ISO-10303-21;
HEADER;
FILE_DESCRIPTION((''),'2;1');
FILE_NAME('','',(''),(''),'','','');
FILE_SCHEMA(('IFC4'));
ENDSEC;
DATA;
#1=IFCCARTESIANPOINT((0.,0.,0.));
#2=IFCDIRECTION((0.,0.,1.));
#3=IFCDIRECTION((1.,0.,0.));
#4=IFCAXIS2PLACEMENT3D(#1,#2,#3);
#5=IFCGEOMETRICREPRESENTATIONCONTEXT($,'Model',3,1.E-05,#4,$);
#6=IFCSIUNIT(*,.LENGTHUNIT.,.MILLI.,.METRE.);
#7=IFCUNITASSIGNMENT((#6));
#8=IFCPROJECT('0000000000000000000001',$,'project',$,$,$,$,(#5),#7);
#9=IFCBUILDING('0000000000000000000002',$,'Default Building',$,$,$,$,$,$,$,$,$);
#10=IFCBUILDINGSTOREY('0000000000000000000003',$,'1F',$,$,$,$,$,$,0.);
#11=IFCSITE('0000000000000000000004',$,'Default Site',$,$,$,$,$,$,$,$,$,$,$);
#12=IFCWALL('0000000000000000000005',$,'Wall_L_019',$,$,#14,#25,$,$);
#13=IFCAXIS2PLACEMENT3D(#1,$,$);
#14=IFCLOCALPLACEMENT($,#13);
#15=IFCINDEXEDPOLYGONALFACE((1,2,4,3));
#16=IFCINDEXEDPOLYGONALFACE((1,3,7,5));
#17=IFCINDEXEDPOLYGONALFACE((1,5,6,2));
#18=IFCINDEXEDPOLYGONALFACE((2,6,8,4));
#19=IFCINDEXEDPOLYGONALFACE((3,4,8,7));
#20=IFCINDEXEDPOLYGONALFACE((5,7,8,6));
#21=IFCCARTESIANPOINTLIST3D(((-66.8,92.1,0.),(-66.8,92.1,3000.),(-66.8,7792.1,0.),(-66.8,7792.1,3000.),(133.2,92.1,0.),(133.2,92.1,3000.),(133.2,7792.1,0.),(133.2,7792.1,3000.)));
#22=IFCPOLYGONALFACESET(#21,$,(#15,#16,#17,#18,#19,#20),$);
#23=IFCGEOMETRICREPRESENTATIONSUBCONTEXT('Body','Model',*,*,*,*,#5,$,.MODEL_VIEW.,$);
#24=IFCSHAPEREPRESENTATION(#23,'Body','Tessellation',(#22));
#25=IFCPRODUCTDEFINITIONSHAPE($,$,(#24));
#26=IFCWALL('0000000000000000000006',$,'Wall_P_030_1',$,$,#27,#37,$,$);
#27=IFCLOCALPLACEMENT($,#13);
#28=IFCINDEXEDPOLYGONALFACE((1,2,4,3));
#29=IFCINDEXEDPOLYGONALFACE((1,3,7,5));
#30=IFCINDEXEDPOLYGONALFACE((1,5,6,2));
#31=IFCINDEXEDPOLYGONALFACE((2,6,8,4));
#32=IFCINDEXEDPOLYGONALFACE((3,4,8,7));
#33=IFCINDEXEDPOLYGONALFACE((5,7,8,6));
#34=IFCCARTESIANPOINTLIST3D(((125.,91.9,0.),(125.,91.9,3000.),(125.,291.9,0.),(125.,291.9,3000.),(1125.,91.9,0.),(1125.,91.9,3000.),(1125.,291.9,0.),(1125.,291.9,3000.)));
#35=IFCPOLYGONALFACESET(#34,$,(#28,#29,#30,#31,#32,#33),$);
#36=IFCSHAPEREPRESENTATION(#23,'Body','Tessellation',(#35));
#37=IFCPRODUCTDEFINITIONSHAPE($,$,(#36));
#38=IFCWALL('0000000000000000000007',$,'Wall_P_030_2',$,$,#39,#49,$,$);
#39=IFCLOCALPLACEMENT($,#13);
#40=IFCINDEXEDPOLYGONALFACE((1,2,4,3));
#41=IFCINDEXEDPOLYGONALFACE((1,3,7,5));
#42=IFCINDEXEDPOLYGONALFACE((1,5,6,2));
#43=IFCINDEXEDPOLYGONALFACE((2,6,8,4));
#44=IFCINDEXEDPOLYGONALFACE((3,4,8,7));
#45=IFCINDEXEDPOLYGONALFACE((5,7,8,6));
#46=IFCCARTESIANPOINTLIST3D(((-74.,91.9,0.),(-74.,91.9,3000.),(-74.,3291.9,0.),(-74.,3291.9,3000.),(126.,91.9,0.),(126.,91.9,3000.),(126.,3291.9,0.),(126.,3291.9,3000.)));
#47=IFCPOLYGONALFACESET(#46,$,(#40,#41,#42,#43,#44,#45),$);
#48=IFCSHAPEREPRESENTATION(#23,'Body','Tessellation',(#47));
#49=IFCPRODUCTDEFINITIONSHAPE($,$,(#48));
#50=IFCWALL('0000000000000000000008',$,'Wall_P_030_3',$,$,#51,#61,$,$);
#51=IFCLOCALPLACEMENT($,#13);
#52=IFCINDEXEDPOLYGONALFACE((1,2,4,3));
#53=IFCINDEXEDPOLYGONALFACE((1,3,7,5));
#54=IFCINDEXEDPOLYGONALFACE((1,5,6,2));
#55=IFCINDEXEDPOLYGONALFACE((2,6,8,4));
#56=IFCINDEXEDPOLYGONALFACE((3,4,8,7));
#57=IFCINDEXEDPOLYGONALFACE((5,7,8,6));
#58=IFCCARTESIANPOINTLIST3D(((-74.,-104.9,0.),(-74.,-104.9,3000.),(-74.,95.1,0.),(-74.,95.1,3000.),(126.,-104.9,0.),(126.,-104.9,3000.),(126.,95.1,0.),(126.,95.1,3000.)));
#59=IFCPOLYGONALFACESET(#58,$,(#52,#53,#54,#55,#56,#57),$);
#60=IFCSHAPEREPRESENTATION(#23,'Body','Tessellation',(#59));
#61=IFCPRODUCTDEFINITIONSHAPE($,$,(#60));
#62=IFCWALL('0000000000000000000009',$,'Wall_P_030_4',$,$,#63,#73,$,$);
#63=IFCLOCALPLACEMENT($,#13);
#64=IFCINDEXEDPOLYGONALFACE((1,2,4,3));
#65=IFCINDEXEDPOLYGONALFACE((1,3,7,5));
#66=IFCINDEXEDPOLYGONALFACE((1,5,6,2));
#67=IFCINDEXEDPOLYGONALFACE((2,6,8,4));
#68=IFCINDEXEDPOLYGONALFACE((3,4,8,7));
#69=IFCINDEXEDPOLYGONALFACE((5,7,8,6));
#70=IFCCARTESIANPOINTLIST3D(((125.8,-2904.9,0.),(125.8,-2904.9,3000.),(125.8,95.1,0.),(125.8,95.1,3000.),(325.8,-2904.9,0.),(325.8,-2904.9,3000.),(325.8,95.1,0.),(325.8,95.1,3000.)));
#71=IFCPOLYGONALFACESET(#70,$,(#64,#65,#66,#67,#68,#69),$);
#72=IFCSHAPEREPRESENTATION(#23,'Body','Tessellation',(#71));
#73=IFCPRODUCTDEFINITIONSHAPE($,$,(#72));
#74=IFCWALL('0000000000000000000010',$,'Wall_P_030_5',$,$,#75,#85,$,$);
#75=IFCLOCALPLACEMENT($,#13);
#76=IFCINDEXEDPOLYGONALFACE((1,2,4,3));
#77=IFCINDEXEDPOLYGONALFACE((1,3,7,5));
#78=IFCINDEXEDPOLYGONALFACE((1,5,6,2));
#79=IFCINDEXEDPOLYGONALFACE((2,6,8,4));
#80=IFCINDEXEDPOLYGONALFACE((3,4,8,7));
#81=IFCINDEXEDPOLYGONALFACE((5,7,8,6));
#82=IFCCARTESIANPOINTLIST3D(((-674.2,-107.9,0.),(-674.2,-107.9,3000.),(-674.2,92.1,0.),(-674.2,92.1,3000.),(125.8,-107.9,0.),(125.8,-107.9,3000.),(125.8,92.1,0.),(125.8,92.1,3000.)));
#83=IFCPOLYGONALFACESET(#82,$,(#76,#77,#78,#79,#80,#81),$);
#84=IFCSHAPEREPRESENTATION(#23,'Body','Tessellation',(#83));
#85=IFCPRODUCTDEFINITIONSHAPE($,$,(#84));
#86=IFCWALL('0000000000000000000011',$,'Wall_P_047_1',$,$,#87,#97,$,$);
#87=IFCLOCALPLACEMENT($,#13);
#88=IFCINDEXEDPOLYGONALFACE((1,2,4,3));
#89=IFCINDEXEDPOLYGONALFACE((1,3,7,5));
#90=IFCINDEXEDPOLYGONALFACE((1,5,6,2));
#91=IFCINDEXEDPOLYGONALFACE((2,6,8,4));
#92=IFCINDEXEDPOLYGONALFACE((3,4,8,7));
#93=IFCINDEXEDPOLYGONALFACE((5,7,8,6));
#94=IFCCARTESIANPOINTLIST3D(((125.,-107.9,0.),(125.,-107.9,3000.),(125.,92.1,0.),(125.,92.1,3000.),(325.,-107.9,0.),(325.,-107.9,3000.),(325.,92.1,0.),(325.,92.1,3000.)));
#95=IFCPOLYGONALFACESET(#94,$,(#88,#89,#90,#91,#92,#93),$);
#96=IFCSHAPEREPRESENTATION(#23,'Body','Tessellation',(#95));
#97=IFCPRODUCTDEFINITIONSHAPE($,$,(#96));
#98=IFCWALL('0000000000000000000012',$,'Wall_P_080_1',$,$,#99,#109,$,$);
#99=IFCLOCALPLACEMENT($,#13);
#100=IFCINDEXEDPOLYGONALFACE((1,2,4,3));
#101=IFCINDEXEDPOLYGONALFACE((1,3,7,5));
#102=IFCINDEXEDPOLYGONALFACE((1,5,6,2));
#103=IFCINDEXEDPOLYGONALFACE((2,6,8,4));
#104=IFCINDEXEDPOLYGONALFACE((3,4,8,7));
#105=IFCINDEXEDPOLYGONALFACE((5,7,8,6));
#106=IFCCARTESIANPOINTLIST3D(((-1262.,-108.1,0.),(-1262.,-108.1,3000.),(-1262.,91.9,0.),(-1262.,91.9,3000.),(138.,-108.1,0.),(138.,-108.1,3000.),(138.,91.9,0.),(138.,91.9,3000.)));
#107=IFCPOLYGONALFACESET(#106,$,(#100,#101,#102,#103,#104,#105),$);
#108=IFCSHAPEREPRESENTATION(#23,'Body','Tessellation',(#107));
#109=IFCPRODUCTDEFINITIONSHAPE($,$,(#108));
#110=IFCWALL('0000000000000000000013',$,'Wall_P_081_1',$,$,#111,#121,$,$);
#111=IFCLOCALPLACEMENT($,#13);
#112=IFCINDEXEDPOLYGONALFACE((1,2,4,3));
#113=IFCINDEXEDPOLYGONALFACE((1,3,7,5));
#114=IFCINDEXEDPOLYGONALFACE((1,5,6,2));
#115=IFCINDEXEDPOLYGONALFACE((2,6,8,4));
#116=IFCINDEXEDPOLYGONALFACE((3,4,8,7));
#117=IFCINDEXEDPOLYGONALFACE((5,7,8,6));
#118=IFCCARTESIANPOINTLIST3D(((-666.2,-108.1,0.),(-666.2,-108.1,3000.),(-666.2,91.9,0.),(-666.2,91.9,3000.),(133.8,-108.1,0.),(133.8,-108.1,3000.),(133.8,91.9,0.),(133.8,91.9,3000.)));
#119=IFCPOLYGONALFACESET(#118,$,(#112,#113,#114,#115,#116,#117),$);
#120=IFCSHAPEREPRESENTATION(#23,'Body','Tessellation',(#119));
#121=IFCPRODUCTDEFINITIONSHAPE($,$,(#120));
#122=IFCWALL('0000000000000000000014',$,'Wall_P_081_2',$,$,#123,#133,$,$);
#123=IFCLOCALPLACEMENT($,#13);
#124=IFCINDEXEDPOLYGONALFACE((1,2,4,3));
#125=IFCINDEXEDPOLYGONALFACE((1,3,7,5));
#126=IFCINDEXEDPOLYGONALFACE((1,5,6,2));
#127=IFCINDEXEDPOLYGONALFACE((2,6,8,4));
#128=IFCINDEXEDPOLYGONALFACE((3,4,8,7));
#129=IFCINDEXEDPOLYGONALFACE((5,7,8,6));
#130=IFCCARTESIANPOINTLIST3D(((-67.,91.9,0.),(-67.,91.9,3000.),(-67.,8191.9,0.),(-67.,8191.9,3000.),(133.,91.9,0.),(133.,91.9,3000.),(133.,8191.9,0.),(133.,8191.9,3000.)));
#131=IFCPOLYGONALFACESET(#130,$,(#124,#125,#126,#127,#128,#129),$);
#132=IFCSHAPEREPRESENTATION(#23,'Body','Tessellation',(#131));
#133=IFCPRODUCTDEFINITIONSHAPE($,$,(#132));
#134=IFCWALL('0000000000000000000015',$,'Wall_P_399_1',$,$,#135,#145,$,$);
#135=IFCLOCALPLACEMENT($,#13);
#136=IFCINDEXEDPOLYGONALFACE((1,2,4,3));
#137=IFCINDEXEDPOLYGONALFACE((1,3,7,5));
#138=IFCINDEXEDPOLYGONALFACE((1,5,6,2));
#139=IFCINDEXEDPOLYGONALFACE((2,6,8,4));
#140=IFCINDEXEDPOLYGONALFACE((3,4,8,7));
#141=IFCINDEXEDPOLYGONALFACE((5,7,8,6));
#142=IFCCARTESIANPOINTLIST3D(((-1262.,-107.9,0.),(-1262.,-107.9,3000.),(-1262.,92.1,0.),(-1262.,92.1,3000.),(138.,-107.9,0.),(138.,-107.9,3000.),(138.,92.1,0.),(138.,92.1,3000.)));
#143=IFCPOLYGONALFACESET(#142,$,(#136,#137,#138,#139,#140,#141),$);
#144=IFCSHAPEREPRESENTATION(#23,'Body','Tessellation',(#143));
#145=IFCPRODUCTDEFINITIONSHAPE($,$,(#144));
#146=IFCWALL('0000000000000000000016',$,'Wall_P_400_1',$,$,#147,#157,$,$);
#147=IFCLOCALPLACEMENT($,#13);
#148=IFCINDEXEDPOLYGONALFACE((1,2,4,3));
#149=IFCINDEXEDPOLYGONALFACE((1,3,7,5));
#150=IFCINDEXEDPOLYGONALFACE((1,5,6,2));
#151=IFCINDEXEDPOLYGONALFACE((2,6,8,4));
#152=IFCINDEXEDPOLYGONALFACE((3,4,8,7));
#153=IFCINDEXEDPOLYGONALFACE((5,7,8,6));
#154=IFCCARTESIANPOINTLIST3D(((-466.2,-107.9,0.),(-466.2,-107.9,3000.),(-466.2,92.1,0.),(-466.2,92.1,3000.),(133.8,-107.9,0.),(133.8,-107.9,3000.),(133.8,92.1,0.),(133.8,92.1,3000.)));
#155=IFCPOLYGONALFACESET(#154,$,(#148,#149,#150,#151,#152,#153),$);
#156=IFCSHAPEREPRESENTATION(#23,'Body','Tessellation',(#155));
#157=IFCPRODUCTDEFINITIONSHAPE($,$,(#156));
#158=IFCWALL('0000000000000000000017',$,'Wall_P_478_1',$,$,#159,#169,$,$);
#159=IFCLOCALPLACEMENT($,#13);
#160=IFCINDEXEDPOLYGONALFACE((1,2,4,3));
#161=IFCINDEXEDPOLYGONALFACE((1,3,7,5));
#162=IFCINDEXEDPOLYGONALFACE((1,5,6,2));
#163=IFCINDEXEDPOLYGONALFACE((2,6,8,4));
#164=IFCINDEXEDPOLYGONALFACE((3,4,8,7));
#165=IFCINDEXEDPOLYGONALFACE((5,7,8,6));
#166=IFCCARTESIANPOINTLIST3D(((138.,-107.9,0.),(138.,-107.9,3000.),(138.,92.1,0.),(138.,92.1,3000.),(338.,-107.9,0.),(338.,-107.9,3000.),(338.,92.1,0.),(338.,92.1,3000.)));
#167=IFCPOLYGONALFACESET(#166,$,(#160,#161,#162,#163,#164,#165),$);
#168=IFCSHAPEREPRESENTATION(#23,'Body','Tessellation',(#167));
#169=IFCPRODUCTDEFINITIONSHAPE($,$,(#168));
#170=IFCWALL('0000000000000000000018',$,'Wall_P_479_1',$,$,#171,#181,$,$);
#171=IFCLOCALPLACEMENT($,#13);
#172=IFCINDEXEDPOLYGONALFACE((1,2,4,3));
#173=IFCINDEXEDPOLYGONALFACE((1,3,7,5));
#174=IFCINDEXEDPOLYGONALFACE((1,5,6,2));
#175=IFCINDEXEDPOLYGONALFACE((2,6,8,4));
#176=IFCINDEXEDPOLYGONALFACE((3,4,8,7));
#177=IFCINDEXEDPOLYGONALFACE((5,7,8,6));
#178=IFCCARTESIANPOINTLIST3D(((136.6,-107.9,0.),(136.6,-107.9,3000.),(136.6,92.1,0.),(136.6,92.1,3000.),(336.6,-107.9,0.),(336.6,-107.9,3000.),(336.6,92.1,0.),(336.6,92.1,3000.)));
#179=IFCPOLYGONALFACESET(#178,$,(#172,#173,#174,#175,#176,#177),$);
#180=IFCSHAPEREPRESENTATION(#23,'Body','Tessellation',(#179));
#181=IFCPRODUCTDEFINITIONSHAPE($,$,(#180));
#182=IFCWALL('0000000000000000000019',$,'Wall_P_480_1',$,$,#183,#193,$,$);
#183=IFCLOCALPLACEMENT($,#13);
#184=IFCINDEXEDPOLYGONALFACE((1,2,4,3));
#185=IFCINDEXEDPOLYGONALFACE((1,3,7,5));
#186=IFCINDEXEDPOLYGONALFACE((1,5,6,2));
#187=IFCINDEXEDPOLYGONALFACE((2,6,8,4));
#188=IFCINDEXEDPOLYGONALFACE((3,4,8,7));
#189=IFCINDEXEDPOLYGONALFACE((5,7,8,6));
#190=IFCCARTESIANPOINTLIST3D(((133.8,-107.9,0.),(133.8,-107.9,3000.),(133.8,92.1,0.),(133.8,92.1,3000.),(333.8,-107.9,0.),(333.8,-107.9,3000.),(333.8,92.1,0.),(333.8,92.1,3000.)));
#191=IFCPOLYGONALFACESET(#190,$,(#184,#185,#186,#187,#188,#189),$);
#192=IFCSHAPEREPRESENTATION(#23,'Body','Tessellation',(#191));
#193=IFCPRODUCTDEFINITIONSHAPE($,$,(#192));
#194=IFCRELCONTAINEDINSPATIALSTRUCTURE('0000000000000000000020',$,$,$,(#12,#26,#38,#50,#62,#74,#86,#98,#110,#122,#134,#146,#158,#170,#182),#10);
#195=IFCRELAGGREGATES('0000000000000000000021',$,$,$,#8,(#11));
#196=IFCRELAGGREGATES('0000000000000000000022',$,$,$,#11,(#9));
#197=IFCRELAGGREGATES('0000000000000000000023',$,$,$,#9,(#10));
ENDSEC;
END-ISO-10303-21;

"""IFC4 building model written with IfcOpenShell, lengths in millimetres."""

from ifc_helpers import new_model, si_unit, frame, origin_with_axes, place, context, subcontext, project, spatial, indexed_curve, outline, extrude, element, save


model = new_model("IFC4")

# Units and contexts
model_context = context("Model", 3, precision=1e-05, world=origin_with_axes())
body_context = subcontext(model_context, "Body", "Model", "MODEL_VIEW")
ifc_project = project(units=[si_unit("LENGTHUNIT", "METRE", prefix="MILLI")], contexts=[model_context])

# Site, building, storey
site = spatial("IfcSite", under=ifc_project, Name="Default Site")
building = spatial("IfcBuilding", under=site, Name="Default Building")
storey = spatial("IfcBuildingStorey", under=building, Name="1F", Elevation=0.0)

# Walls
wall_1_placement = place(None, frame((133.2, 92.1, 0.0), z_axis=(0.0, 0.0, 1.0), x_axis=(0.0, 1.0, 0.0)))
element("IfcWall", 1, at=wall_1_placement, inside=storey, Name="Wall_L_019", context=body_context, shape_type="SweptSolid", body=[
    extrude(outline(indexed_curve([(0.0, 0.0), (0.0, 200.0), (7700.0, 200.0), (7700.0, 0.0), (0.0, 0.0)], self_intersect=False)), origin_with_axes(), (0.0, 0.0, 1.0), 3000.0),
])
wall_2_placement = place(None, frame((125.0, 91.9, 0.0), z_axis=(0.0, 0.0, 1.0), x_axis=(1.0, 0.0, 0.0)))
element("IfcWall", 2, at=wall_2_placement, inside=storey, Name="Wall_P_030_1", context=body_context, shape_type="SweptSolid", body=[
    extrude(outline(indexed_curve([(0.0, 0.0), (0.0, 200.0), (1000.0, 200.0), (1000.0, 0.0), (0.0, 0.0)], self_intersect=False)), origin_with_axes(), (0.0, 0.0, 1.0), 3000.0),
])
wall_3_placement = place(None, frame((126.0, 91.9, 0.0), z_axis=(0.0, 0.0, 1.0), x_axis=(0.0, 1.0, 0.0)))
element("IfcWall", 3, at=wall_3_placement, inside=storey, Name="Wall_P_030_2", context=body_context, shape_type="SweptSolid", body=[
    extrude(outline(indexed_curve([(0.0, 0.0), (0.0, 200.0), (3200.0, 200.0), (3200.0, 0.0), (0.0, 0.0)], self_intersect=False)), origin_with_axes(), (0.0, 0.0, 1.0), 3000.0),
])
wall_4_placement = place(None, frame((126.0, 95.1, 0.0), z_axis=(0.0, 0.0, 1.0), x_axis=(-1.0, 0.0, 0.0)))
element("IfcWall", 4, at=wall_4_placement, inside=storey, Name="Wall_P_030_3", context=body_context, shape_type="SweptSolid", body=[
    extrude(outline(indexed_curve([(0.0, 0.0), (0.0, 200.0), (200.0, 200.0), (200.0, 0.0), (0.0, 0.0)], self_intersect=False)), origin_with_axes(), (0.0, 0.0, 1.0), 3000.0),
])
wall_5_placement = place(None, frame((125.8, 95.1, 0.0), z_axis=(0.0, 0.0, 1.0), x_axis=(0.0, -1.0, 0.0)))
element("IfcWall", 5, at=wall_5_placement, inside=storey, Name="Wall_P_030_4", context=body_context, shape_type="SweptSolid", body=[
    extrude(outline(indexed_curve([(0.0, 0.0), (0.0, 200.0), (3000.0, 200.0), (3000.0, 0.0), (0.0, 0.0)], self_intersect=False)), origin_with_axes(), (0.0, 0.0, 1.0), 3000.0),
])
wall_6_placement = place(None, frame((125.8, 92.1, 0.0), z_axis=(0.0, 0.0, 1.0), x_axis=(-1.0, 0.0, 0.0)))
element("IfcWall", 6, at=wall_6_placement, inside=storey, Name="Wall_P_030_5", context=body_context, shape_type="SweptSolid", body=[
    extrude(outline(indexed_curve([(0.0, 0.0), (0.0, 200.0), (800.0, 200.0), (800.0, 0.0), (0.0, 0.0)], self_intersect=False)), origin_with_axes(), (0.0, 0.0, 1.0), 3000.0),
])
wall_7_placement = place(None, frame((125.0, 92.1, 0.0), z_axis=(0.0, 0.0, 1.0), x_axis=(0.0, -1.0, 0.0)))
element("IfcWall", 7, at=wall_7_placement, inside=storey, Name="Wall_P_047_1", context=body_context, shape_type="SweptSolid", body=[
    extrude(outline(indexed_curve([(0.0, 0.0), (0.0, 200.0), (200.0, 200.0), (200.0, 0.0), (0.0, 0.0)], self_intersect=False)), origin_with_axes(), (0.0, 0.0, 1.0), 3000.0),
])
wall_8_placement = place(None, frame((138.0, 91.9, 0.0), z_axis=(0.0, 0.0, 1.0), x_axis=(-1.0, 0.0, 0.0)))
element("IfcWall", 8, at=wall_8_placement, inside=storey, Name="Wall_P_080_1", context=body_context, shape_type="SweptSolid", body=[
    extrude(outline(indexed_curve([(0.0, 0.0), (0.0, 200.0), (1400.0, 200.0), (1400.0, 0.0), (0.0, 0.0)], self_intersect=False)), origin_with_axes(), (0.0, 0.0, 1.0), 3000.0),
])
wall_9_placement = place(None, frame((133.8, 91.9, 0.0), z_axis=(0.0, 0.0, 1.0), x_axis=(-1.0, 0.0, 0.0)))
element("IfcWall", 9, at=wall_9_placement, inside=storey, Name="Wall_P_081_1", context=body_context, shape_type="SweptSolid", body=[
    extrude(outline(indexed_curve([(0.0, 0.0), (0.0, 200.0), (800.0, 200.0), (800.0, 0.0), (0.0, 0.0)], self_intersect=False)), origin_with_axes(), (0.0, 0.0, 1.0), 3000.0),
])
wall_10_placement = place(None, frame((133.0, 91.9, 0.0), z_axis=(0.0, 0.0, 1.0), x_axis=(0.0, 1.0, 0.0)))
element("IfcWall", 10, at=wall_10_placement, inside=storey, Name="Wall_P_081_2", context=body_context, shape_type="SweptSolid", body=[
    extrude(outline(indexed_curve([(0.0, 0.0), (0.0, 200.0), (8100.0, 200.0), (8100.0, 0.0), (0.0, 0.0)], self_intersect=False)), origin_with_axes(), (0.0, 0.0, 1.0), 3000.0),
])
wall_11_placement = place(None, frame((138.0, 92.1, 0.0), z_axis=(0.0, 0.0, 1.0), x_axis=(-1.0, 0.0, 0.0)))
element("IfcWall", 11, at=wall_11_placement, inside=storey, Name="Wall_P_399_1", context=body_context, shape_type="SweptSolid", body=[
    extrude(outline(indexed_curve([(0.0, 0.0), (0.0, 200.0), (1400.0, 200.0), (1400.0, 0.0), (0.0, 0.0)], self_intersect=False)), origin_with_axes(), (0.0, 0.0, 1.0), 3000.0),
])
wall_12_placement = place(None, frame((133.8, 92.1, 0.0), z_axis=(0.0, 0.0, 1.0), x_axis=(-1.0, 0.0, 0.0)))
element("IfcWall", 12, at=wall_12_placement, inside=storey, Name="Wall_P_400_1", context=body_context, shape_type="SweptSolid", body=[
    extrude(outline(indexed_curve([(0.0, 0.0), (0.0, 200.0), (600.0, 200.0), (600.0, 0.0), (0.0, 0.0)], self_intersect=False)), origin_with_axes(), (0.0, 0.0, 1.0), 3000.0),
])
for number, where, z_axis, x_axis, name in (
    (13, (138.0, 92.1, 0.0), (0.0, 0.0, 1.0), (0.0, -1.0, 0.0), "Wall_P_478_1"),
    (14, (136.6, 92.1, 0.0), (0.0, 0.0, 1.0), (0.0, -1.0, 0.0), "Wall_P_479_1"),
    (15, (133.8, 92.1, 0.0), (0.0, 0.0, 1.0), (0.0, -1.0, 0.0), "Wall_P_480_1"),
):
    element("IfcWall", number, at=place(None, frame(where, z_axis=z_axis, x_axis=x_axis)), inside=storey, Name=name, context=body_context, shape_type="SweptSolid", body=[
        extrude(outline(indexed_curve([(0.0, 0.0), (0.0, 200.0), (200.0, 200.0), (200.0, 0.0), (0.0, 0.0)], self_intersect=False)), origin_with_axes(), (0.0, 0.0, 1.0), 3000.0),
    ])

save(model, "model.ifc")
